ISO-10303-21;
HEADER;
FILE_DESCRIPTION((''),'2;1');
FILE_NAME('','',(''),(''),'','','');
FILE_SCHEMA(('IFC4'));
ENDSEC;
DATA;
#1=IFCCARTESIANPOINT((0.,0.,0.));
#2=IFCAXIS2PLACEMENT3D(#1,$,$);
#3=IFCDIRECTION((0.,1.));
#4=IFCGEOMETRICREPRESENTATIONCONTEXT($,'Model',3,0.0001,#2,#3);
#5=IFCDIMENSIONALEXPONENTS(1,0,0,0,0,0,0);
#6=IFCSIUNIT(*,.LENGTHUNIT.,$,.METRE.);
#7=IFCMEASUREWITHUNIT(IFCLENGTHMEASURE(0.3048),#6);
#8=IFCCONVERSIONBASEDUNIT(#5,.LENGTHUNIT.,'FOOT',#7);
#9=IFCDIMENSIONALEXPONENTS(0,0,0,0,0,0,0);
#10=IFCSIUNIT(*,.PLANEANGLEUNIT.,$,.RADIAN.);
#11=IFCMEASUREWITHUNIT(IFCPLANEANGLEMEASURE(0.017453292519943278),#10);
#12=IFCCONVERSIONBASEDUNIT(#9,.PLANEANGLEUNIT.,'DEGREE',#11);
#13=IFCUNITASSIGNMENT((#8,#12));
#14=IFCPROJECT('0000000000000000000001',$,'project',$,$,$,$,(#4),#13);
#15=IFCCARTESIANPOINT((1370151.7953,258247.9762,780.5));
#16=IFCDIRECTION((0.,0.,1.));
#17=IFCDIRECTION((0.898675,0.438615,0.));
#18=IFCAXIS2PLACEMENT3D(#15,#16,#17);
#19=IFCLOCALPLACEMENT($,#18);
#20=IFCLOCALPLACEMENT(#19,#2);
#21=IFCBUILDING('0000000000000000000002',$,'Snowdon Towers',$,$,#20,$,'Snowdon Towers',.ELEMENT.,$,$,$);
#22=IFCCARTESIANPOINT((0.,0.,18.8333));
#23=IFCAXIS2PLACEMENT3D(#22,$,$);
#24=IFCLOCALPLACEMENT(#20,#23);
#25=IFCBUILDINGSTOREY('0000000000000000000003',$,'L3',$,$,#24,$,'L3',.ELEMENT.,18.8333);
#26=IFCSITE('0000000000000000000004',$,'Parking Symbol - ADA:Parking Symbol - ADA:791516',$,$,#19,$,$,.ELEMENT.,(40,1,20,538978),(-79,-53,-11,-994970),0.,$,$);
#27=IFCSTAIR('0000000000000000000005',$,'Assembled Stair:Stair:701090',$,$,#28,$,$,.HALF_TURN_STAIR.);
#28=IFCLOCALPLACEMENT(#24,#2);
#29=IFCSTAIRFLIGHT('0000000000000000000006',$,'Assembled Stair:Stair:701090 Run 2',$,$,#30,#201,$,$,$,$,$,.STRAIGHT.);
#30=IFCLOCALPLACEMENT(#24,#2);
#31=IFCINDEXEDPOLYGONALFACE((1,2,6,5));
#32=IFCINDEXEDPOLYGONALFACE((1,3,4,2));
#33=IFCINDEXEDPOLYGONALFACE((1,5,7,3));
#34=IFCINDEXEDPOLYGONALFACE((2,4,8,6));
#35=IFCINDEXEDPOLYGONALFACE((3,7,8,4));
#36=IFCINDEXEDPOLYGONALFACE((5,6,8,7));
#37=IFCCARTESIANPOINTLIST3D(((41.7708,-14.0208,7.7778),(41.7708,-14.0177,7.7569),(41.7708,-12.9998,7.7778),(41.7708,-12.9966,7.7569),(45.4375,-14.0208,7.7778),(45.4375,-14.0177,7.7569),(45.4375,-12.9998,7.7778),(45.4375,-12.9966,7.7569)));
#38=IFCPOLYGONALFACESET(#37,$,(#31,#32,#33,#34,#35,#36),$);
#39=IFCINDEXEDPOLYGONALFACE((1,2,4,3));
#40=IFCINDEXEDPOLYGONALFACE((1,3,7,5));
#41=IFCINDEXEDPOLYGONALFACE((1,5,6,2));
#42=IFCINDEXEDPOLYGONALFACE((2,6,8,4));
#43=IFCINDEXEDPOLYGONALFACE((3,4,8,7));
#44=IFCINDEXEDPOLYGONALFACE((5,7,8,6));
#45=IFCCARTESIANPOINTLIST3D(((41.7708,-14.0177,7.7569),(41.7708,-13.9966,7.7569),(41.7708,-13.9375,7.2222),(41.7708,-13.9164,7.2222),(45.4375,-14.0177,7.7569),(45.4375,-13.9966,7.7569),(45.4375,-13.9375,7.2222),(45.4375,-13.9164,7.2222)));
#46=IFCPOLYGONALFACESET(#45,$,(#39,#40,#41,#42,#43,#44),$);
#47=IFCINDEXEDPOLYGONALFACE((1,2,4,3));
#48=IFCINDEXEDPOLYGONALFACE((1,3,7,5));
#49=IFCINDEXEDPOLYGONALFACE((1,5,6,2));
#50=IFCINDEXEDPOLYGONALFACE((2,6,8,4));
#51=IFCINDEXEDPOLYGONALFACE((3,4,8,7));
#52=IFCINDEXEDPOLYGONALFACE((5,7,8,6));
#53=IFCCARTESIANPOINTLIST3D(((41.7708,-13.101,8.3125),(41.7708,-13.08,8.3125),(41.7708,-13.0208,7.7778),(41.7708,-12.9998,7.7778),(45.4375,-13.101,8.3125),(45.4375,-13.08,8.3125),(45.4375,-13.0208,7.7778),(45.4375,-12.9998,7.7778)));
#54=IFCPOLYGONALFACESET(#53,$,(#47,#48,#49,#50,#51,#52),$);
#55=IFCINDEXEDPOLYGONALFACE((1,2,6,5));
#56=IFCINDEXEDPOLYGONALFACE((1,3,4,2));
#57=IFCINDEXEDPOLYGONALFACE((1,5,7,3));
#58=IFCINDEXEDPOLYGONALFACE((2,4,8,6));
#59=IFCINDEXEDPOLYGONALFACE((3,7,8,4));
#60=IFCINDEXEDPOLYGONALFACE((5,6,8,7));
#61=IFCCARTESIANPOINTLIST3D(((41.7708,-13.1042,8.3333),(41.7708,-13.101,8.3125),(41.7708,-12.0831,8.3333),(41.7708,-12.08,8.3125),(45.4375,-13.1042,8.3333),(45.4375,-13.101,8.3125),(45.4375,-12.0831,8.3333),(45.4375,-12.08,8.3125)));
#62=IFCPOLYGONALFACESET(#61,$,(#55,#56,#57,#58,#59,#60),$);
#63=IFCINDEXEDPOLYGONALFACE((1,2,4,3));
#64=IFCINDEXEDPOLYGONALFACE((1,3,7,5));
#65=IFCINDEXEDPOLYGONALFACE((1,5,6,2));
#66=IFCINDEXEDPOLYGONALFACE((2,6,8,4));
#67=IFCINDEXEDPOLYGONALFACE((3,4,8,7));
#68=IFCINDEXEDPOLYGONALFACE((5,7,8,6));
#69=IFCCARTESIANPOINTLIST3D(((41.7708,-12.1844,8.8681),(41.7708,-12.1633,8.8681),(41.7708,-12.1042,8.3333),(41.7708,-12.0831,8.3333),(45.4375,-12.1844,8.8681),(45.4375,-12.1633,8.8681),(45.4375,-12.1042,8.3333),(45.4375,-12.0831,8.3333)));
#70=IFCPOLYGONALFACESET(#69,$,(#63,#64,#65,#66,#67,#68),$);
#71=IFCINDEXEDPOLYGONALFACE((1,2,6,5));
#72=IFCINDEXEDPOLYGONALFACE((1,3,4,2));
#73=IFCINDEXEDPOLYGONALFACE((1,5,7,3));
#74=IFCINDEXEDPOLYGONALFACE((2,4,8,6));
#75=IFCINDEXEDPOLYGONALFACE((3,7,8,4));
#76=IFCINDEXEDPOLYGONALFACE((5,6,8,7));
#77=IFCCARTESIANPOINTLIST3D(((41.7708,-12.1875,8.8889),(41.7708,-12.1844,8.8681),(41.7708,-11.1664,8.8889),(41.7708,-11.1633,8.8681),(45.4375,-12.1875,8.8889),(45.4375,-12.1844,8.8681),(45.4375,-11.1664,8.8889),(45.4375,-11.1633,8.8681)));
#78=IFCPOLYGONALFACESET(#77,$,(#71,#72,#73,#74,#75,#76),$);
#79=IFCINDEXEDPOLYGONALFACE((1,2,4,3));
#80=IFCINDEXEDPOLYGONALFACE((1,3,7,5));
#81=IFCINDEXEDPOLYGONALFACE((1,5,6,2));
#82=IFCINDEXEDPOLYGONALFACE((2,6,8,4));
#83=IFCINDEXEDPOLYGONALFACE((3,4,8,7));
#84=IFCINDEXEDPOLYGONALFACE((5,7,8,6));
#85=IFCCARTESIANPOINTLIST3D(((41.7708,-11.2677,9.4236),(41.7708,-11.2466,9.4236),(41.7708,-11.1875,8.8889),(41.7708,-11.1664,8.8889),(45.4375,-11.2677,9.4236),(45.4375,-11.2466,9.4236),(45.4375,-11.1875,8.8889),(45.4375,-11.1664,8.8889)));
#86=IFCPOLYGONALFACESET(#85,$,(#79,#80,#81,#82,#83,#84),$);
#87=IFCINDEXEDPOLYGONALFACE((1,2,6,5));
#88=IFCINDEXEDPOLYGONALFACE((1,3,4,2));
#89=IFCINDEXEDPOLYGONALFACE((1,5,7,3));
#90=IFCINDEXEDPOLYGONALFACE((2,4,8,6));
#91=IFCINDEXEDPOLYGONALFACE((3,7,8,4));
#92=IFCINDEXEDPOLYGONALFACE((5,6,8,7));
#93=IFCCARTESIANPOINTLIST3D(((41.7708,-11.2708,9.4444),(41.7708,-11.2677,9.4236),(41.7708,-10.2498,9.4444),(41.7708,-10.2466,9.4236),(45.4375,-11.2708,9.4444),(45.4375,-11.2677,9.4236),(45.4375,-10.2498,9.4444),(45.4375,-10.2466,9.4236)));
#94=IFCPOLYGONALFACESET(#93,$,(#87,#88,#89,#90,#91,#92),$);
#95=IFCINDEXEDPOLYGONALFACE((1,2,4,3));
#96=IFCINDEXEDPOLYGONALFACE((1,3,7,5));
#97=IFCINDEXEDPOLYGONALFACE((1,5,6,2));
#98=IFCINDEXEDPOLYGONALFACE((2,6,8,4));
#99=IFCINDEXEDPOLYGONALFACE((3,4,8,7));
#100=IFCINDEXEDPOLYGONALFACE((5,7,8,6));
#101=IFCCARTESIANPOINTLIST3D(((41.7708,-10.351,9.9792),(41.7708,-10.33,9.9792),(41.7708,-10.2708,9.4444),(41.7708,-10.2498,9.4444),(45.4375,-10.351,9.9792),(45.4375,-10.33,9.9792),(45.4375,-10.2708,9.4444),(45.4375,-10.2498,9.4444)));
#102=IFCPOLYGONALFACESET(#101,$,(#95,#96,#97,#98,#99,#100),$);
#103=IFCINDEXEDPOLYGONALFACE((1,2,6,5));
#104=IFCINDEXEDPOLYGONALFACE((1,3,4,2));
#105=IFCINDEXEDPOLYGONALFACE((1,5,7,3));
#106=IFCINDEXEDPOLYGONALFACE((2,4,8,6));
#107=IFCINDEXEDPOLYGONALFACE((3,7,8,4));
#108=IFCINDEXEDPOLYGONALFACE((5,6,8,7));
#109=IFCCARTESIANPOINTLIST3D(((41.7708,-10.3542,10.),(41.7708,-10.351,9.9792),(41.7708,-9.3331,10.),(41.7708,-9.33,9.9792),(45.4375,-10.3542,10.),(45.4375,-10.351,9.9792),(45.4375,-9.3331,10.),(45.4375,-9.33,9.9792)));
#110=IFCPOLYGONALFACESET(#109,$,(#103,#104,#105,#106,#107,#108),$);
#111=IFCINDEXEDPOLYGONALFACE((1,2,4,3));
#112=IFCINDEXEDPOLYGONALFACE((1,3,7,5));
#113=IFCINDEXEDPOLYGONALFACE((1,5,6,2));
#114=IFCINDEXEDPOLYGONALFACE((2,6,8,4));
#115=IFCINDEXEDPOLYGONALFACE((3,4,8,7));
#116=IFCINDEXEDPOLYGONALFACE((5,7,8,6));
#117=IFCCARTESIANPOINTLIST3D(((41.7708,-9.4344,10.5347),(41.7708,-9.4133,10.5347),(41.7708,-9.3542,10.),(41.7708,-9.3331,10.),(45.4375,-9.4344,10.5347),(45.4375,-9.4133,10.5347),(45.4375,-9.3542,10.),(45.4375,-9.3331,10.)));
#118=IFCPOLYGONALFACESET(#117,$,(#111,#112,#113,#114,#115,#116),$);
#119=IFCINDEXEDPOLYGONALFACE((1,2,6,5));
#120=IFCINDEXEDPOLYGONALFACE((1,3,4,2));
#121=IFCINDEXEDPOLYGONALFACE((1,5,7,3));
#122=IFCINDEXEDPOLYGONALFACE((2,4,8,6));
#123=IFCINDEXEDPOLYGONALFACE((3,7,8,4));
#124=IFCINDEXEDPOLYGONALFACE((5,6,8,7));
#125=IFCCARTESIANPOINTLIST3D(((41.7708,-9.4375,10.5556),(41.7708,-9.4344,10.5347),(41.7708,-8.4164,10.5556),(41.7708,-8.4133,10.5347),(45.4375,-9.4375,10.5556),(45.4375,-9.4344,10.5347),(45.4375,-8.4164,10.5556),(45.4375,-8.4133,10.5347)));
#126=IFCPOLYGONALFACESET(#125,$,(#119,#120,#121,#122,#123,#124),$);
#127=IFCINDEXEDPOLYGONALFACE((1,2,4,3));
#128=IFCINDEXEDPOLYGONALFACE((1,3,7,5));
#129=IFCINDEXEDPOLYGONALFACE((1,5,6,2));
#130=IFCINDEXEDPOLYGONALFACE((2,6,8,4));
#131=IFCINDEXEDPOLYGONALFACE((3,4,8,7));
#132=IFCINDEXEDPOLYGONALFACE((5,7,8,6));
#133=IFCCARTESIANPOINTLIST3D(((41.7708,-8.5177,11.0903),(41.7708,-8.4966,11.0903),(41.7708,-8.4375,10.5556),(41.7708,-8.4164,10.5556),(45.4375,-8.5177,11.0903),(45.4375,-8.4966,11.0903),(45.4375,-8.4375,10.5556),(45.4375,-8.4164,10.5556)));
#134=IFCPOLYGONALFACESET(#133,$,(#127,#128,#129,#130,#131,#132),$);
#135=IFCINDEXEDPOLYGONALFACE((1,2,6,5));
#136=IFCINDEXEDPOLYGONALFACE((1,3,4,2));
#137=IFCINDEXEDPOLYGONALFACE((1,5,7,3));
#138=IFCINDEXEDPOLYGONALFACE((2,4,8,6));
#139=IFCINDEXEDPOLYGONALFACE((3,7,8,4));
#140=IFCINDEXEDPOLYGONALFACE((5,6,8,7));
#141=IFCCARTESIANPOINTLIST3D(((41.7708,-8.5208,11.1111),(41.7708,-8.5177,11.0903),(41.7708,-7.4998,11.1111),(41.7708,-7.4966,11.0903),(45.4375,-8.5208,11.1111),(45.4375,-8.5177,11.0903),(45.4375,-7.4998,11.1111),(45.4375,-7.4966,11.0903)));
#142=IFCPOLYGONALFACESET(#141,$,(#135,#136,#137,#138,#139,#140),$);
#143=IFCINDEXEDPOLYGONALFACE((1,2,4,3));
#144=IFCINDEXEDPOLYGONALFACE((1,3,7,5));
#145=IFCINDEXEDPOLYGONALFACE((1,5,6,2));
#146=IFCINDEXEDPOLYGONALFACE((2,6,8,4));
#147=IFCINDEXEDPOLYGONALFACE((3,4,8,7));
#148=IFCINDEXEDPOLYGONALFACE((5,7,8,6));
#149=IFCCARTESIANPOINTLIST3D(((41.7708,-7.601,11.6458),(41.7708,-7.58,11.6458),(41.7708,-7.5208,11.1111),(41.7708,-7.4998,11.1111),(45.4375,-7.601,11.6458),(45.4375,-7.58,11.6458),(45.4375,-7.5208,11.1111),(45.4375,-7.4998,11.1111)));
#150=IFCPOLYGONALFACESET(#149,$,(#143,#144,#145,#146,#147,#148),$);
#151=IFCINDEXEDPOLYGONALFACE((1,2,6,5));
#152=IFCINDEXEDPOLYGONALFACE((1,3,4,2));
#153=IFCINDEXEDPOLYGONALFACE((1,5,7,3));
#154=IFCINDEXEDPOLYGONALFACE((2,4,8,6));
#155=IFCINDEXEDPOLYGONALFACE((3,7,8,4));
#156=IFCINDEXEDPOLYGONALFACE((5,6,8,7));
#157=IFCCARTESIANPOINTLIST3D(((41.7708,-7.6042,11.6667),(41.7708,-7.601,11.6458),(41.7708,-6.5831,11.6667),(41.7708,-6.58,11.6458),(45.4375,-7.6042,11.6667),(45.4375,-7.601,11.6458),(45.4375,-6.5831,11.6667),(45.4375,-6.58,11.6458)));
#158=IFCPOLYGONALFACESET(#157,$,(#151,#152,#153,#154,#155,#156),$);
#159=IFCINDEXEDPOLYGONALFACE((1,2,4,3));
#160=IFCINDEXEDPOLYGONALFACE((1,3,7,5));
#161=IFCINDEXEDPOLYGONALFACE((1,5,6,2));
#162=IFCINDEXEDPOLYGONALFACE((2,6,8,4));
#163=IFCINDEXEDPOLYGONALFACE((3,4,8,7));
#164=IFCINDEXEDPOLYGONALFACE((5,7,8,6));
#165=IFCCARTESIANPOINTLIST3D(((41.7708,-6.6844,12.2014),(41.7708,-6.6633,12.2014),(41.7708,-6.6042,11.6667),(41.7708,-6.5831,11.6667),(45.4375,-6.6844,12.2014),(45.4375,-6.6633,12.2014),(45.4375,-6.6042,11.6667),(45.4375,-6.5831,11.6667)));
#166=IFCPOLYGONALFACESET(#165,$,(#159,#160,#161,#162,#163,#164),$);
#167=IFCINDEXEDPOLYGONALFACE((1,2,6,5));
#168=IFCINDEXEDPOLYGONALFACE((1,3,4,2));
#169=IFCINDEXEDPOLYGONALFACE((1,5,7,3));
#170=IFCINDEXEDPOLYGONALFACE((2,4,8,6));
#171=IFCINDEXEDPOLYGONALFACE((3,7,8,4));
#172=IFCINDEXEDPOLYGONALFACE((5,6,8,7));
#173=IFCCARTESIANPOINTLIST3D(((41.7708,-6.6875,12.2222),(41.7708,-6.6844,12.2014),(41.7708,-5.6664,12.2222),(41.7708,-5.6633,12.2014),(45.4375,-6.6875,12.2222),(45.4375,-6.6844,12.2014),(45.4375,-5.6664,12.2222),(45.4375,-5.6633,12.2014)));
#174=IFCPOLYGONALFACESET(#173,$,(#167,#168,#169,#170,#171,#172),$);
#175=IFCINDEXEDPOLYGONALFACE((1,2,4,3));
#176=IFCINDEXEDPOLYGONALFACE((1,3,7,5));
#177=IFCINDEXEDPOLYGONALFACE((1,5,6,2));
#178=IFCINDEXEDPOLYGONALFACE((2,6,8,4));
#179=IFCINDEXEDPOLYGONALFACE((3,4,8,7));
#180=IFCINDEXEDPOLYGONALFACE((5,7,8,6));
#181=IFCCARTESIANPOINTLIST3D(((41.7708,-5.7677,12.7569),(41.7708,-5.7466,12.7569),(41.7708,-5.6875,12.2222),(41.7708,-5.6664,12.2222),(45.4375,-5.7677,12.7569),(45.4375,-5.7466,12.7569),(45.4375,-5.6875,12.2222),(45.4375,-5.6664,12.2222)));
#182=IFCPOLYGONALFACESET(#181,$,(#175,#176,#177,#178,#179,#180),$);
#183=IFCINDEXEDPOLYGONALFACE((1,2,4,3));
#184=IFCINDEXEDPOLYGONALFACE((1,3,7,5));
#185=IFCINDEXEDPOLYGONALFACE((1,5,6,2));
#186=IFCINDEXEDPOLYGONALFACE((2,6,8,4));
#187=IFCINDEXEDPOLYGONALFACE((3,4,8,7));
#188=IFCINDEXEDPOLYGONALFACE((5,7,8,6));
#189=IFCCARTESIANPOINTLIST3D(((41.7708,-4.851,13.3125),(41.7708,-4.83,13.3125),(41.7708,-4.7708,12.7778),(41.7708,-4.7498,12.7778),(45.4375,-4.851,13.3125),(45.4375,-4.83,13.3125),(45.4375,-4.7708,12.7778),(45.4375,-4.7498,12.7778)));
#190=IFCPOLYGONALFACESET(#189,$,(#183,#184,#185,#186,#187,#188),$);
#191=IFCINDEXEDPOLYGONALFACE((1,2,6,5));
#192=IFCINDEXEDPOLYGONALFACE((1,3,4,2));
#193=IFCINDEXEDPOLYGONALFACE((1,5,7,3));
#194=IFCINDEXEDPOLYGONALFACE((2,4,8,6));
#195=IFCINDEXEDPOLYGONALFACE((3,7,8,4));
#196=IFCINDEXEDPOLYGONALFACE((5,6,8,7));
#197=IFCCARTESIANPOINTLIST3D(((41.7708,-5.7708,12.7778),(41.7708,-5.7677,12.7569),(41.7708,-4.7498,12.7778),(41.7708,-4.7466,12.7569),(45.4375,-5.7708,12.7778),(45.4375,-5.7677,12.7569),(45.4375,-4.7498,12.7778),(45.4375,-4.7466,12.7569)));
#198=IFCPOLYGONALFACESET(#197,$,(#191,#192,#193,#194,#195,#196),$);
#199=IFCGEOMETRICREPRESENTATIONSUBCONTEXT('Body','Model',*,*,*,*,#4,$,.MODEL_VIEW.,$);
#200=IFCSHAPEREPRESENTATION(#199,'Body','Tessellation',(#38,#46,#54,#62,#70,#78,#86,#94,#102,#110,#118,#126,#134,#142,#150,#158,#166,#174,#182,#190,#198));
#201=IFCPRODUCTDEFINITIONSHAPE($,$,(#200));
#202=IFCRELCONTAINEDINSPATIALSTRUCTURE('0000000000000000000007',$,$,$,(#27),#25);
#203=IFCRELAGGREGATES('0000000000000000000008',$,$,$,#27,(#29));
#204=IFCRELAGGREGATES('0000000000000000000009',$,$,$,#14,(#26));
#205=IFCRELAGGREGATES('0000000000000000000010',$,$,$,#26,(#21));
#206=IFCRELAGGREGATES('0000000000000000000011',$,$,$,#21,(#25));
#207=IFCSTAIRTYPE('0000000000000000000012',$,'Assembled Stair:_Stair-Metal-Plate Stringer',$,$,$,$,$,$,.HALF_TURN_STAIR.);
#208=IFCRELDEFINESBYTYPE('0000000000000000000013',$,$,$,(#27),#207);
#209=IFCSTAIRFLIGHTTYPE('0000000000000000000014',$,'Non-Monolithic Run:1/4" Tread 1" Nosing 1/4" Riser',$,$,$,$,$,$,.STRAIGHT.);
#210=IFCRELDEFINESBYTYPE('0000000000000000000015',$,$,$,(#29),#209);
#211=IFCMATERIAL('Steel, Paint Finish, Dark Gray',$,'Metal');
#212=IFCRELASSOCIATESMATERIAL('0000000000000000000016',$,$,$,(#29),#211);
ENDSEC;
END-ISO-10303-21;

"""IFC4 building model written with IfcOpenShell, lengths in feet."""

from ifc_helpers import new_model, entity, si_unit, converted_unit, direction, frame, origin, place, context, subcontext, project, spatial, indexed_curve, outline, extrude, material, type_object, element, aggregate, save


model = new_model("IFC4")

# Units and contexts
model_context = context("Model", 3, precision=0.0001, world=origin(), true_north=direction((0.0, 1.0)))
body_context = subcontext(model_context, "Body", "Model", "MODEL_VIEW")
ifc_project = project(units=[converted_unit("LENGTHUNIT", "FOOT", entity("IfcLengthMeasure", 0.3048), si_unit("LENGTHUNIT", "METRE"), dimensions=[1, 0, 0, 0, 0, 0, 0]), converted_unit("PLANEANGLEUNIT", "DEGREE", entity("IfcPlaneAngleMeasure", 0.017453292519943278), si_unit("PLANEANGLEUNIT", "RADIAN"), dimensions=[0, 0, 0, 0, 0, 0, 0])], contexts=[model_context])

# Site, building, storey
site_placement = place(None, frame((1370151.7953, 258247.9762, 780.5), z_axis=(0.0, 0.0, 1.0), x_axis=(0.898675, 0.438615, 0.0)))
site = spatial("IfcSite", under=ifc_project, at=site_placement, Name="Parking Symbol - ADA:Parking Symbol - ADA:791516", CompositionType="ELEMENT", RefLatitude=(40, 1, 20, 538978), RefLongitude=(-79, -53, -11, -994970), RefElevation=0.0)
building_placement = place(site_placement, origin())
building = spatial("IfcBuilding", under=site, at=building_placement, Name="Snowdon Towers", LongName="Snowdon Towers", CompositionType="ELEMENT")
storey_placement = place(building_placement, frame((0.0, 0.0, 18.8333)))
storey = spatial("IfcBuildingStorey", under=building, at=storey_placement, Name="L3", LongName="L3", CompositionType="ELEMENT", Elevation=18.8333)

# Stair
stair_type = type_object("IfcStairType", Name="Assembled Stair:_Stair-Metal-Plate Stringer", PredefinedType="HALF_TURN_STAIR")
ifc_material_1 = material(Name="Steel, Paint Finish, Dark Gray", Category="Metal")
stair_1_placement = place(storey_placement, origin())
stair_1 = element("IfcStair", 1, at=stair_1_placement, inside=storey, type_object=stair_type, Name="Assembled Stair:Stair:701090", PredefinedType="HALF_TURN_STAIR")

# Stair flight
stair_flight_type = type_object("IfcStairFlightType", Name="Non-Monolithic Run:1/4\" Tread 1\" Nosing 1/4\" Riser", PredefinedType="STRAIGHT")
stair_flight_1_placement = place(stair_1_placement, origin())
stair_flight_1 = element("IfcStairFlight", 2, at=stair_flight_1_placement, type_object=stair_flight_type, material=ifc_material_1, Name="Assembled Stair:Stair:701090 Run 2", PredefinedType="STRAIGHT", context=body_context, shape_type="SweptSolid", body=[
    extrude(outline(indexed_curve([(-0.0863, -0.5049), (-0.0652, -0.5049), (0.0863, 0.5049), (0.0652, 0.5049), (-0.0863, -0.5049)], self_intersect=False)), frame((41.7708, -13.5087, 7.7674), z_axis=(1.0, 0.0, 0.0), x_axis=(0.0, 0.14834, -0.988936)), (0.0, 0.0, 1.0), 3.6667),
    extrude(outline(indexed_curve([(-0.2719, -0.0104), (0.2688, -0.0104), (0.2719, 0.0104), (-0.2688, 0.0104), (-0.2719, -0.0104)], self_intersect=False)), frame((41.7708, -13.9671, 7.4896), z_axis=(1.0, 0.0, 0.0), x_axis=(0.0, 0.14834, -0.988936)), (0.0, 0.0, 1.0), 3.6667),
    extrude(outline(indexed_curve([(-0.2719, -0.0104), (0.2688, -0.0104), (0.2719, 0.0104), (-0.2688, 0.0104), (-0.2719, -0.0104)], self_intersect=False)), frame((41.7708, -13.0504, 8.0451), z_axis=(1.0, 0.0, 0.0), x_axis=(0.0, 0.14834, -0.988936)), (0.0, 0.0, 1.0), 3.6667),
    extrude(outline(indexed_curve([(-0.0863, -0.5049), (-0.0652, -0.5049), (0.0863, 0.5049), (0.0652, 0.5049), (-0.0863, -0.5049)], self_intersect=False)), frame((41.7708, -12.5921, 8.3229), z_axis=(1.0, 0.0, 0.0), x_axis=(0.0, 0.14834, -0.988936)), (0.0, 0.0, 1.0), 3.6667),
    extrude(outline(indexed_curve([(-0.2719, -0.0104), (0.2688, -0.0104), (0.2719, 0.0104), (-0.2688, 0.0104), (-0.2719, -0.0104)], self_intersect=False)), frame((41.7708, -12.1337, 8.6007), z_axis=(1.0, 0.0, 0.0), x_axis=(0.0, 0.14834, -0.988936)), (0.0, 0.0, 1.0), 3.6667),
    extrude(outline(indexed_curve([(-0.0863, -0.5049), (-0.0652, -0.5049), (0.0863, 0.5049), (0.0652, 0.5049), (-0.0863, -0.5049)], self_intersect=False)), frame((41.7708, -11.6754, 8.8785), z_axis=(1.0, 0.0, 0.0), x_axis=(0.0, 0.14834, -0.988936)), (0.0, 0.0, 1.0), 3.6667),
    extrude(outline(indexed_curve([(-0.2719, -0.0104), (0.2688, -0.0104), (0.2719, 0.0104), (-0.2688, 0.0104), (-0.2719, -0.0104)], self_intersect=False)), frame((41.7708, -11.2171, 9.1563), z_axis=(1.0, 0.0, 0.0), x_axis=(0.0, 0.14834, -0.988936)), (0.0, 0.0, 1.0), 3.6667),
    extrude(outline(indexed_curve([(-0.0863, -0.5049), (-0.0652, -0.5049), (0.0863, 0.5049), (0.0652, 0.5049), (-0.0863, -0.5049)], self_intersect=False)), frame((41.7708, -10.7587, 9.434), z_axis=(1.0, 0.0, 0.0), x_axis=(0.0, 0.14834, -0.988936)), (0.0, 0.0, 1.0), 3.6667),
    extrude(outline(indexed_curve([(-0.2719, -0.0104), (0.2688, -0.0104), (0.2719, 0.0104), (-0.2688, 0.0104), (-0.2719, -0.0104)], self_intersect=False)), frame((41.7708, -10.3004, 9.7118), z_axis=(1.0, 0.0, 0.0), x_axis=(0.0, 0.14834, -0.988936)), (0.0, 0.0, 1.0), 3.6667),
    extrude(outline(indexed_curve([(-0.0863, -0.5049), (-0.0652, -0.5049), (0.0863, 0.5049), (0.0652, 0.5049), (-0.0863, -0.5049)], self_intersect=False)), frame((41.7708, -9.8421, 9.9896), z_axis=(1.0, 0.0, 0.0), x_axis=(0.0, 0.14834, -0.988936)), (0.0, 0.0, 1.0), 3.6667),
    extrude(outline(indexed_curve([(-0.2719, -0.0104), (0.2688, -0.0104), (0.2719, 0.0104), (-0.2688, 0.0104), (-0.2719, -0.0104)], self_intersect=False)), frame((41.7708, -9.3837, 10.2674), z_axis=(1.0, 0.0, 0.0), x_axis=(0.0, 0.14834, -0.988936)), (0.0, 0.0, 1.0), 3.6667),
    extrude(outline(indexed_curve([(-0.0863, -0.5049), (-0.0652, -0.5049), (0.0863, 0.5049), (0.0652, 0.5049), (-0.0863, -0.5049)], self_intersect=False)), frame((41.7708, -8.9254, 10.5451), z_axis=(1.0, 0.0, 0.0), x_axis=(0.0, 0.14834, -0.988936)), (0.0, 0.0, 1.0), 3.6667),
    extrude(outline(indexed_curve([(-0.2719, -0.0104), (0.2688, -0.0104), (0.2719, 0.0104), (-0.2688, 0.0104), (-0.2719, -0.0104)], self_intersect=False)), frame((41.7708, -8.4671, 10.8229), z_axis=(1.0, 0.0, 0.0), x_axis=(0.0, 0.14834, -0.988936)), (0.0, 0.0, 1.0), 3.6667),
    extrude(outline(indexed_curve([(-0.0863, -0.5049), (-0.0652, -0.5049), (0.0863, 0.5049), (0.0652, 0.5049), (-0.0863, -0.5049)], self_intersect=False)), frame((41.7708, -8.0087, 11.1007), z_axis=(1.0, 0.0, 0.0), x_axis=(0.0, 0.14834, -0.988936)), (0.0, 0.0, 1.0), 3.6667),
    extrude(outline(indexed_curve([(-0.2719, -0.0104), (0.2688, -0.0104), (0.2719, 0.0104), (-0.2688, 0.0104), (-0.2719, -0.0104)], self_intersect=False)), frame((41.7708, -7.5504, 11.3785), z_axis=(1.0, 0.0, 0.0), x_axis=(0.0, 0.14834, -0.988936)), (0.0, 0.0, 1.0), 3.6667),
    extrude(outline(indexed_curve([(-0.0863, -0.5049), (-0.0652, -0.5049), (0.0863, 0.5049), (0.0652, 0.5049), (-0.0863, -0.5049)], self_intersect=False)), frame((41.7708, -7.0921, 11.6563), z_axis=(1.0, 0.0, 0.0), x_axis=(0.0, 0.14834, -0.988936)), (0.0, 0.0, 1.0), 3.6667),
    extrude(outline(indexed_curve([(-0.2719, -0.0104), (0.2688, -0.0104), (0.2719, 0.0104), (-0.2688, 0.0104), (-0.2719, -0.0104)], self_intersect=False)), frame((41.7708, -6.6337, 11.934), z_axis=(1.0, 0.0, 0.0), x_axis=(0.0, 0.14834, -0.988936)), (0.0, 0.0, 1.0), 3.6667),
    extrude(outline(indexed_curve([(-0.0863, -0.5049), (-0.0652, -0.5049), (0.0863, 0.5049), (0.0652, 0.5049), (-0.0863, -0.5049)], self_intersect=False)), frame((41.7708, -6.1754, 12.2118), z_axis=(1.0, 0.0, 0.0), x_axis=(0.0, 0.14834, -0.988936)), (0.0, 0.0, 1.0), 3.6667),
    extrude(outline(indexed_curve([(-0.2719, -0.0104), (0.2688, -0.0104), (0.2719, 0.0104), (-0.2688, 0.0104), (-0.2719, -0.0104)], self_intersect=False)), frame((41.7708, -5.7171, 12.4896), z_axis=(1.0, 0.0, 0.0), x_axis=(0.0, 0.14834, -0.988936)), (0.0, 0.0, 1.0), 3.6667),
    extrude(outline(indexed_curve([(-0.2719, -0.0104), (0.2688, -0.0104), (0.2719, 0.0104), (-0.2688, 0.0104), (-0.2719, -0.0104)], self_intersect=False)), frame((41.7708, -4.8004, 13.0451), z_axis=(1.0, 0.0, 0.0), x_axis=(0.0, 0.14834, -0.988936)), (0.0, 0.0, 1.0), 3.6667),
    extrude(outline(indexed_curve([(-0.0863, -0.5049), (-0.0652, -0.5049), (0.0863, 0.5049), (0.0652, 0.5049), (-0.0863, -0.5049)], self_intersect=False)), frame((41.7708, -5.2587, 12.7674), z_axis=(1.0, 0.0, 0.0), x_axis=(0.0, 0.14834, -0.988936)), (0.0, 0.0, 1.0), 3.6667),
])
aggregate(stair_1, [stair_flight_1])

save(model, "model.ifc")
